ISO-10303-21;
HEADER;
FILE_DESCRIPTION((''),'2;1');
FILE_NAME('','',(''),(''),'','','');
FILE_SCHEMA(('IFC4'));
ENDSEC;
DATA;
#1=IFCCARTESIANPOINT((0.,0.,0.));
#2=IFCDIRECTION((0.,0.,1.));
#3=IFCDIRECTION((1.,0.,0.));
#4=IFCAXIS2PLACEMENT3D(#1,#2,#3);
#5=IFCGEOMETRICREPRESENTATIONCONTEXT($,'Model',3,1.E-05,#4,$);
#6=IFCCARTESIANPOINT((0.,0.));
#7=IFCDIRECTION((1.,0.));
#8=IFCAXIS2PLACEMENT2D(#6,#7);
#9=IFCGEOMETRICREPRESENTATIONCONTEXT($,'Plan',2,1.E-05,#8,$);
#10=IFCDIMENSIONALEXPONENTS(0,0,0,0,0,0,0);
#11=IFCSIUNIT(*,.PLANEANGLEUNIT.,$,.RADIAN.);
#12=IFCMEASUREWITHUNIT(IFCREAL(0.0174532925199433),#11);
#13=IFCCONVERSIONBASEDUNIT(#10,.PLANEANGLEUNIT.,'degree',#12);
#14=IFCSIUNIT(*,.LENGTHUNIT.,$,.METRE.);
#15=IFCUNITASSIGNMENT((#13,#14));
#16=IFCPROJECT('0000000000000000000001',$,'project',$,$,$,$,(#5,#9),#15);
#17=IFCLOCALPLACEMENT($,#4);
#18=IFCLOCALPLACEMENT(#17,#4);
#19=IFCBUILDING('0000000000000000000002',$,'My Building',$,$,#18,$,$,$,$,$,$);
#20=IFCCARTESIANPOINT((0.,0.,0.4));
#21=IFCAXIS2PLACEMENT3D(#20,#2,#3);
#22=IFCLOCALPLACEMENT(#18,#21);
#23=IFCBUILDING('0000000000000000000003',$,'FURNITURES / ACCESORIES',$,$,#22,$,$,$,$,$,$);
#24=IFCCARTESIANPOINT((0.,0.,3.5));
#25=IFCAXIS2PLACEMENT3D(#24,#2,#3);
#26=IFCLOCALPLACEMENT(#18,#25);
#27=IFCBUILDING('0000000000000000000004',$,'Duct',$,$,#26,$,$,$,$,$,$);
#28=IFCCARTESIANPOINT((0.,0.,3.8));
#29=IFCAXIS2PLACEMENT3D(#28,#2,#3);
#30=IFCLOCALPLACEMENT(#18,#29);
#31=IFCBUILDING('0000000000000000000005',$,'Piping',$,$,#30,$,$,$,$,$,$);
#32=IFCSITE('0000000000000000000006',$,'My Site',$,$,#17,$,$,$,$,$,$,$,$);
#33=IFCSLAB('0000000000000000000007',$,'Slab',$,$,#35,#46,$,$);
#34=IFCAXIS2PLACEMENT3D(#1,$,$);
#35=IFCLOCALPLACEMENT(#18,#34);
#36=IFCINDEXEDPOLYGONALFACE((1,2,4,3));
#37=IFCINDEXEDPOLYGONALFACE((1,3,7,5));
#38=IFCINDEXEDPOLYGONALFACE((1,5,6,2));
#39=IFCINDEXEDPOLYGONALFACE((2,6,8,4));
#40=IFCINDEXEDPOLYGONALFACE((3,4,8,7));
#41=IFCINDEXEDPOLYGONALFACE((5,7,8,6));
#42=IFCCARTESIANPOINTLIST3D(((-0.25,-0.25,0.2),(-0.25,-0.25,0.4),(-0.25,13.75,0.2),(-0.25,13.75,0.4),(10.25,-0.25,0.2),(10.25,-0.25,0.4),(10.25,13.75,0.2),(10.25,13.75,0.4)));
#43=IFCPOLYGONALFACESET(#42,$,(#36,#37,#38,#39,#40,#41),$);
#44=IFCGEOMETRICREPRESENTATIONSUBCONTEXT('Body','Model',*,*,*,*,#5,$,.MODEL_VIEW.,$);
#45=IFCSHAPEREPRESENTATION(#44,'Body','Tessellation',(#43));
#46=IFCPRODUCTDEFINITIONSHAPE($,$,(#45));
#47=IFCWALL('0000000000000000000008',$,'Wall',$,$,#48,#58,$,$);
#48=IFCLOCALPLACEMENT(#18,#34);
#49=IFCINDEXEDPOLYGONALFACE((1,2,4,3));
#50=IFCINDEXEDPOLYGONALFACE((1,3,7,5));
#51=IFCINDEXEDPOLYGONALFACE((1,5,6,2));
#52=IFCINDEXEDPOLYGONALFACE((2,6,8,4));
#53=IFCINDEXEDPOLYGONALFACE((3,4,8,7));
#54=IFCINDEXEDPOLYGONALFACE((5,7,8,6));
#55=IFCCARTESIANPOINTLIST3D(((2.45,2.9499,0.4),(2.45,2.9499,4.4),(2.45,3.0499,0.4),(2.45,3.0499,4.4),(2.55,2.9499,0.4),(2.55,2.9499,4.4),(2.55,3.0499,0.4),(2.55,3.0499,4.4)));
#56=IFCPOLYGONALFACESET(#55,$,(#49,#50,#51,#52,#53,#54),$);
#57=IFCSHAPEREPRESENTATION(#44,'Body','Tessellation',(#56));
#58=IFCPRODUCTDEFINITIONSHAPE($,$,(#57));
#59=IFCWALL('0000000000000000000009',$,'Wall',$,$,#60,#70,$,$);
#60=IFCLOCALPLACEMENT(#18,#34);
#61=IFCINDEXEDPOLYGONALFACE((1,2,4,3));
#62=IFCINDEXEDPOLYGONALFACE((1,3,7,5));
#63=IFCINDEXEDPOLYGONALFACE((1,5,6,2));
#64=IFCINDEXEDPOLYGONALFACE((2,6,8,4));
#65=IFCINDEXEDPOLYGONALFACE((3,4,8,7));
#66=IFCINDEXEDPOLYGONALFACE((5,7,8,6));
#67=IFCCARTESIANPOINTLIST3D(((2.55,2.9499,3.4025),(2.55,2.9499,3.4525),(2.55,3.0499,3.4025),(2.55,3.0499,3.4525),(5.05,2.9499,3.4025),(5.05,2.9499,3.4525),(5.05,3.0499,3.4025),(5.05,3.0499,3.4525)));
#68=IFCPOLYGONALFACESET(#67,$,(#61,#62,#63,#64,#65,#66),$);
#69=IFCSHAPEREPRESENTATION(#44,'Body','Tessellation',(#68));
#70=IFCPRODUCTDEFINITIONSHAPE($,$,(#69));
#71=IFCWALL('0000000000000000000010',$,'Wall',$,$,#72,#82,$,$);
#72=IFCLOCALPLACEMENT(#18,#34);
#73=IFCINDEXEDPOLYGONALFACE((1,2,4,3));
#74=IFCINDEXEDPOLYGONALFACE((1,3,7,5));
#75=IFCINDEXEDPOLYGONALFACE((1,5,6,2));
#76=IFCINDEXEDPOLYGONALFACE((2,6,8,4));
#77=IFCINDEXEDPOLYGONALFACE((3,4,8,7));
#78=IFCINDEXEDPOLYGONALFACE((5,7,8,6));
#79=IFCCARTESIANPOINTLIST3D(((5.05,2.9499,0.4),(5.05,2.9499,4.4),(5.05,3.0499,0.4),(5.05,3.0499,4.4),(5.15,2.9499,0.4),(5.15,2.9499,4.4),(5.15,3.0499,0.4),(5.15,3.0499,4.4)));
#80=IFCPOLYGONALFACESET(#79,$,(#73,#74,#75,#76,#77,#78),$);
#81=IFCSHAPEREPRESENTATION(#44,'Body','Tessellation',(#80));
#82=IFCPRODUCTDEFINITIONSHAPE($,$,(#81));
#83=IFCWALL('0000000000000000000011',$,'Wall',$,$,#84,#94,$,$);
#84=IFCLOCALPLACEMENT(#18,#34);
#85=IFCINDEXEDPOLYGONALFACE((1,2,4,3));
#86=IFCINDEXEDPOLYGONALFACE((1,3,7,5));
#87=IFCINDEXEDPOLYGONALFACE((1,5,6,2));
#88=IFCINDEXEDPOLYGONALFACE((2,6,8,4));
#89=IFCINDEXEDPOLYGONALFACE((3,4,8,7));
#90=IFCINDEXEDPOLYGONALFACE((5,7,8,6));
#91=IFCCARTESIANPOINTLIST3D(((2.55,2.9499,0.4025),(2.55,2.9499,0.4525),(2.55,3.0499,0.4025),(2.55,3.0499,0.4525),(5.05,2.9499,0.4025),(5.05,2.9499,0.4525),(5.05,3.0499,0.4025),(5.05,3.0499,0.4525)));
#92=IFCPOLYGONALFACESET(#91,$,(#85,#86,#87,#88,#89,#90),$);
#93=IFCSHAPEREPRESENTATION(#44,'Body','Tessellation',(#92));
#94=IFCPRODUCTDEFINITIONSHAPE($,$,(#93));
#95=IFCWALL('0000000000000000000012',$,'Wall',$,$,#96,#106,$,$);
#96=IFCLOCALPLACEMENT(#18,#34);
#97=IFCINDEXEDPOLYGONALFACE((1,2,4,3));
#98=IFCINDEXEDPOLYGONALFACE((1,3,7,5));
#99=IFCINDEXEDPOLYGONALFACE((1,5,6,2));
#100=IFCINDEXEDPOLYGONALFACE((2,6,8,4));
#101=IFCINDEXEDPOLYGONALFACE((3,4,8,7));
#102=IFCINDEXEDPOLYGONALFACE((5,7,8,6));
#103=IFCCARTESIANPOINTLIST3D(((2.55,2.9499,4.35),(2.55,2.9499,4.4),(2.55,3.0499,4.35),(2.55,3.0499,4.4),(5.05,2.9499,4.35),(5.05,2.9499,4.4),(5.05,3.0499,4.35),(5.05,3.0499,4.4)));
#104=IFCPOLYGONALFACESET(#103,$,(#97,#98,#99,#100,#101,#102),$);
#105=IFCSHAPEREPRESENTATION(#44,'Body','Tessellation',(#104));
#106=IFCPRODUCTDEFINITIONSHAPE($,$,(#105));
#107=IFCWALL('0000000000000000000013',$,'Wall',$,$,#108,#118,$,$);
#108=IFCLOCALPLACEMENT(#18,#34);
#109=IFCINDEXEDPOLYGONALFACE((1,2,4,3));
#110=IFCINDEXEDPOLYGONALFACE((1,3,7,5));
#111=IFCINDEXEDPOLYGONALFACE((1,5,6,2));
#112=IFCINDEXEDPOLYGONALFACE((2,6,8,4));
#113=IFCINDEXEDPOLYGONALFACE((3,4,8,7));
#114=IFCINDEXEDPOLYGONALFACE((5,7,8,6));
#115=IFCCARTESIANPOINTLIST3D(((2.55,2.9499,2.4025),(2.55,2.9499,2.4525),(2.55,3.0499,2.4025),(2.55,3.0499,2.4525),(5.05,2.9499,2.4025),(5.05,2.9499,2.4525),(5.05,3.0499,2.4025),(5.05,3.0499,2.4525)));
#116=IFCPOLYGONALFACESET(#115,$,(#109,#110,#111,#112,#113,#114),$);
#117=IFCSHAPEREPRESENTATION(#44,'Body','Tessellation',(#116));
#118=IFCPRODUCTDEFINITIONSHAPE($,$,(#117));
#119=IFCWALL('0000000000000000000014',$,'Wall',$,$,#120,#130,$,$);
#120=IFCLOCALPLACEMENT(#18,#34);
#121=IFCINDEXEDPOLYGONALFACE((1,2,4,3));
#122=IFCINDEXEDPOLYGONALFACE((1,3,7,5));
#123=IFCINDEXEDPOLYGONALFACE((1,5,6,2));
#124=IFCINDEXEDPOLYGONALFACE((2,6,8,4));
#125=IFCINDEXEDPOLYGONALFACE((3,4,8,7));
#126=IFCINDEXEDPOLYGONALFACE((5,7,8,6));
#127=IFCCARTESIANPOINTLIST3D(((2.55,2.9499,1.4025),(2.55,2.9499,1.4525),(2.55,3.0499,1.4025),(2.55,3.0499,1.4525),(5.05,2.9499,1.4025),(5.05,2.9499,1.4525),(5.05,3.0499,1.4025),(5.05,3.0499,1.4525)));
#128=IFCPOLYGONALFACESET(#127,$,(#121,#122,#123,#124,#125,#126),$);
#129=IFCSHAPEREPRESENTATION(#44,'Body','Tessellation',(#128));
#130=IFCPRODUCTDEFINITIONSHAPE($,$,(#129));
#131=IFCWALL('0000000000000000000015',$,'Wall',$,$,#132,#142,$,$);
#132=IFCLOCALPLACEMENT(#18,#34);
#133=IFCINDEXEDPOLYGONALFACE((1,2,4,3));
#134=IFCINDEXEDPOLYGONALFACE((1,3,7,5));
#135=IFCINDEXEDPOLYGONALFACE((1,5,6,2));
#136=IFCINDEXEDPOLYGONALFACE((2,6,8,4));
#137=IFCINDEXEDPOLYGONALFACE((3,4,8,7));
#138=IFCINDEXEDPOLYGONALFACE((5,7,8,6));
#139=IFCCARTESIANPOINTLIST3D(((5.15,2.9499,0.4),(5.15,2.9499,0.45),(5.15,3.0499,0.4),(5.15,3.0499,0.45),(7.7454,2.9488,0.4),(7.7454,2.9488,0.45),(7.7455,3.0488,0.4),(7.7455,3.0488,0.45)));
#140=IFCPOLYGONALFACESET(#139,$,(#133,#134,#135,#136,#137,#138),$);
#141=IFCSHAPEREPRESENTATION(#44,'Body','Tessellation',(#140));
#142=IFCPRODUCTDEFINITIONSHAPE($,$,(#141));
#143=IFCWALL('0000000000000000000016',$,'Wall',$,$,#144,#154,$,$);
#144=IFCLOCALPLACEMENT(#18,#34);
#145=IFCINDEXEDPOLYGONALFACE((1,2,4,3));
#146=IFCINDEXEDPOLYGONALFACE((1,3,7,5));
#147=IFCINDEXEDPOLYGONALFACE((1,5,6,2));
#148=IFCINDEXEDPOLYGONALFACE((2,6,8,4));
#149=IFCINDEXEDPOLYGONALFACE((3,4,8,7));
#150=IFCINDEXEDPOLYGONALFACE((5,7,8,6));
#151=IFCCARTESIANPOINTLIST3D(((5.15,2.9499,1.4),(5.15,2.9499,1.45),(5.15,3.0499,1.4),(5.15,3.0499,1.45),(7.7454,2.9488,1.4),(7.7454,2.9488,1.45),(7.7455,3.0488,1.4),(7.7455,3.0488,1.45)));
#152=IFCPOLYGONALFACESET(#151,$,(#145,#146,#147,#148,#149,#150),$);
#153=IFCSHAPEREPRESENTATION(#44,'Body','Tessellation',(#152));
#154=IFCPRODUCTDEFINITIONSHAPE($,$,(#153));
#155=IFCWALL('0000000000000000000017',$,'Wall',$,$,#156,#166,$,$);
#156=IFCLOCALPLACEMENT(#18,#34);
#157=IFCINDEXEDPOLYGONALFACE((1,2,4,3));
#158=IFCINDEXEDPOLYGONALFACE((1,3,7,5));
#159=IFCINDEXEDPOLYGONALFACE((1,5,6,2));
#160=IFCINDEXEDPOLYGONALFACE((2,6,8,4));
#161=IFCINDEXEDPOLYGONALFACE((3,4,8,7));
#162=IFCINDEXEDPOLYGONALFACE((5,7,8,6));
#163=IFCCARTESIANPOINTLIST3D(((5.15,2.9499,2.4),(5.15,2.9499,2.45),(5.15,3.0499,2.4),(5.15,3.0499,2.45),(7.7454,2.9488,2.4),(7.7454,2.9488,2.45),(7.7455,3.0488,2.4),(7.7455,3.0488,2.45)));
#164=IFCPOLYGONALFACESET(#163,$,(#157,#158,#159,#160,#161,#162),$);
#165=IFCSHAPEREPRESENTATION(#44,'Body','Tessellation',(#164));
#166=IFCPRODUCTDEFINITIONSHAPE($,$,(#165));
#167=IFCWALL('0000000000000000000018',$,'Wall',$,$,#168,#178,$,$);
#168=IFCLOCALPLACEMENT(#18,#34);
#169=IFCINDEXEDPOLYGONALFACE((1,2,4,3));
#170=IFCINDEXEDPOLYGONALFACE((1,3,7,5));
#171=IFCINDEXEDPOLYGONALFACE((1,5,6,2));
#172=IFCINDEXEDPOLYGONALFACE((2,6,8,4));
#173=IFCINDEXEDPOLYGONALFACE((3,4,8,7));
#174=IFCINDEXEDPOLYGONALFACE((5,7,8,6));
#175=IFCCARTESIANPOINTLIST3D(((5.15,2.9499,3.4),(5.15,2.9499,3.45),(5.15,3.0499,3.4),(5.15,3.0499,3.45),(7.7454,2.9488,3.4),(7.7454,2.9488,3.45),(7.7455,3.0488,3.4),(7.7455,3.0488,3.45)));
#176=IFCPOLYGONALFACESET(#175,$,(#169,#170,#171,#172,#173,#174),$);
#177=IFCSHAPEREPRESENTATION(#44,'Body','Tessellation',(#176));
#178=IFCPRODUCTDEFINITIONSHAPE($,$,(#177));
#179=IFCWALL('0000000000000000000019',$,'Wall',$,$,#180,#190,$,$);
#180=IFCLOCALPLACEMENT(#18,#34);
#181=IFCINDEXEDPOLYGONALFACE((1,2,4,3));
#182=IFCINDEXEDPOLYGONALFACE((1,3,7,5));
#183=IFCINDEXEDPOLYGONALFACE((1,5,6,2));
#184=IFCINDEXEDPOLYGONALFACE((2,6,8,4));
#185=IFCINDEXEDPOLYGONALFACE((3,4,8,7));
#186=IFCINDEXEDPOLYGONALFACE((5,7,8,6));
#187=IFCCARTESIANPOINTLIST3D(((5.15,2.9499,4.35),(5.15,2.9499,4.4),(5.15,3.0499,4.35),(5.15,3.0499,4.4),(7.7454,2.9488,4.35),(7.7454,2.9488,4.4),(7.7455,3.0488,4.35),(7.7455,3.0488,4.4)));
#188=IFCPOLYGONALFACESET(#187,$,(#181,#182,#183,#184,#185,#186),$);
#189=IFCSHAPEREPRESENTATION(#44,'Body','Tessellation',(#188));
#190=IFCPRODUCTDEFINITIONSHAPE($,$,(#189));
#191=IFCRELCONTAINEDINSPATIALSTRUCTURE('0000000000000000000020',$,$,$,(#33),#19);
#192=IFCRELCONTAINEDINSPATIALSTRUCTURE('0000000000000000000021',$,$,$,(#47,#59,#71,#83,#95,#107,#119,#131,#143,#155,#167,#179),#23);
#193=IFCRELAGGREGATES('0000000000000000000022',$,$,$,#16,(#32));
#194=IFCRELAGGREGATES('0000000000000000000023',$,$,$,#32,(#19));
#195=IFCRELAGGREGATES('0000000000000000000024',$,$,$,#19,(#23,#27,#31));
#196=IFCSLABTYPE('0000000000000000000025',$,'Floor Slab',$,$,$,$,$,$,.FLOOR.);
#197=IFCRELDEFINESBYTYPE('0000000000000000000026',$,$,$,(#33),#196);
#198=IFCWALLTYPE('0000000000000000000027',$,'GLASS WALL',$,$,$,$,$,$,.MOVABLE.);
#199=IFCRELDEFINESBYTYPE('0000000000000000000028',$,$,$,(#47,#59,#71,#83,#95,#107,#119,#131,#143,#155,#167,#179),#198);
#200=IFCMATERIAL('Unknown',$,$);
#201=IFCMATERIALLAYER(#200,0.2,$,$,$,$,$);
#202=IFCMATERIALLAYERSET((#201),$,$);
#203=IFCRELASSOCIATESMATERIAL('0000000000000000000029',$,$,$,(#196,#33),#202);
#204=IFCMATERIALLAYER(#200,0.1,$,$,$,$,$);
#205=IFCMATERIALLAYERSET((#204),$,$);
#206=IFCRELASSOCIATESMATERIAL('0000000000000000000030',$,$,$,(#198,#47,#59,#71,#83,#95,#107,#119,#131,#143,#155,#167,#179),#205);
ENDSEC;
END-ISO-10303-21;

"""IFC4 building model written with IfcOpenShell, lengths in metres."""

from ifc_helpers import new_model, entity, si_unit, converted_unit, frame, origin_with_axes, origin_2d_with_axis, place, context, subcontext, project, spatial, line, indexed_curve, outline, extrude, material, layer, layer_set, layer_usage, type_object, element, save


model = new_model("IFC4")

# Units and contexts
model_context = context("Model", 3, precision=1e-05, world=origin_with_axes())
plan_context = context("Plan", 2, precision=1e-05, world=origin_2d_with_axis())
body_context = subcontext(model_context, "Body", "Model", "MODEL_VIEW")
ifc_project = project(units=[converted_unit("PLANEANGLEUNIT", "degree", entity("IfcReal", 0.0174532925199433), si_unit("PLANEANGLEUNIT", "RADIAN"), dimensions=[0, 0, 0, 0, 0, 0, 0]), si_unit("LENGTHUNIT", "METRE")], contexts=[model_context, plan_context])

# Site, building
site_placement = place(None, origin_with_axes())
site = spatial("IfcSite", under=ifc_project, at=site_placement, Name="My Site")
building_1_placement = place(site_placement, origin_with_axes())
building_1 = spatial("IfcBuilding", under=site, at=building_1_placement, Name="My Building")

# Slab
ifc_material = material(Name="Unknown")
ifc_layer_1 = layer(ifc_material, 0.2)
ifc_layer_set_1 = layer_set([ifc_layer_1])
ifc_layer_usage_1 = layer_usage(ifc_layer_set_1, "AXIS3", "POSITIVE", 0.0)
slab_type = type_object("IfcSlabType", Name="Floor Slab", PredefinedType="FLOOR", material=ifc_layer_set_1)
slab_placement = place(building_1_placement, frame((-0.25, -0.25, 0.2), z_axis=(0.0, 0.0, 1.0), x_axis=(1.0, 0.0, 0.0)))
element("IfcSlab", 1, at=slab_placement, inside=building_1, type_object=slab_type, material=ifc_layer_usage_1, Name="Slab", context=body_context, shape_type="SweptSolid", body=[
    extrude(outline(indexed_curve([(0.0, 0.0), (10.5, 0.0), (10.5, 14.0), (0.0, 14.0), (0.0, 0.0)])), None, (0.0, 0.0, 1.0), 0.2),
])

# Shared definitions
building_2_placement = place(building_1_placement, frame((0.0, 0.0, 0.4), z_axis=(0.0, 0.0, 1.0), x_axis=(1.0, 0.0, 0.0)))
building_2 = spatial("IfcBuilding", under=building_1, at=building_2_placement, Name="FURNITURES / ACCESORIES")

# Walls
ifc_layer_2 = layer(ifc_material, 0.1)
ifc_layer_set_2 = layer_set([ifc_layer_2])
ifc_layer_usage_2 = layer_usage(ifc_layer_set_2, "AXIS2", "POSITIVE", 0.0)
wall_type = type_object("IfcWallType", Name="GLASS WALL", PredefinedType="MOVABLE", material=ifc_layer_set_2)
wall_1_placement = place(building_2_placement, frame((2.45, 2.9499, 0.0), z_axis=(0.0, 0.0, 1.0), x_axis=(1.0, 0.0, 0.0)))
element("IfcWall", 2, at=wall_1_placement, inside=building_2, type_object=wall_type, material=ifc_layer_usage_2, Name="Wall", context=body_context, shape_type="SweptSolid", body=[
    extrude(outline(indexed_curve([(0.0, 0.0), (0.0, 0.1), (0.1, 0.1), (0.1, 0.0)], segments=[line(1, 2, 3, 4, 1)])), origin_with_axes(), (0.0, 0.0, 1.0), 4.0),
])
ifc_layer_usage_3 = layer_usage(ifc_layer_set_2, "AXIS2", "POSITIVE", 0.0)
wall_2_placement = place(building_2_placement, frame((2.55, 2.9499, 3.0025), z_axis=(0.0, 0.0, 1.0), x_axis=(1.0, 0.0, 0.0)))
element("IfcWall", 3, at=wall_2_placement, inside=building_2, type_object=wall_type, material=ifc_layer_usage_3, Name="Wall", context=body_context, shape_type="SweptSolid", body=[
    extrude(outline(indexed_curve([(0.0, 0.0), (0.0, 0.1), (2.5, 0.1), (2.5, 0.0)], segments=[line(1, 2, 3, 4, 1)])), origin_with_axes(), (0.0, 0.0, 1.0), 0.05),
])
ifc_layer_usage_4 = layer_usage(ifc_layer_set_2, "AXIS2", "POSITIVE", 0.0)
wall_3_placement = place(building_2_placement, frame((5.05, 2.9499, 0.0), z_axis=(0.0, 0.0, 1.0), x_axis=(1.0, 0.0, 0.0)))
element("IfcWall", 4, at=wall_3_placement, inside=building_2, type_object=wall_type, material=ifc_layer_usage_4, Name="Wall", context=body_context, shape_type="SweptSolid", body=[
    extrude(outline(indexed_curve([(0.0, 0.0), (0.0, 0.1), (0.1, 0.1), (0.1, 0.0)], segments=[line(1, 2, 3, 4, 1)])), origin_with_axes(), (0.0, 0.0, 1.0), 4.0),
])
ifc_layer_usage_5 = layer_usage(ifc_layer_set_2, "AXIS2", "POSITIVE", 0.0)
wall_4_placement = place(building_2_placement, frame((2.55, 2.9499, 0.0025), z_axis=(0.0, 0.0, 1.0), x_axis=(1.0, 0.0, 0.0)))
element("IfcWall", 5, at=wall_4_placement, inside=building_2, type_object=wall_type, material=ifc_layer_usage_5, Name="Wall", context=body_context, shape_type="SweptSolid", body=[
    extrude(outline(indexed_curve([(0.0, 0.0), (0.0, 0.1), (2.5, 0.1), (2.5, 0.0)], segments=[line(1, 2, 3, 4, 1)])), origin_with_axes(), (0.0, 0.0, 1.0), 0.05),
])
ifc_layer_usage_6 = layer_usage(ifc_layer_set_2, "AXIS2", "POSITIVE", 0.0)
wall_5_placement = place(building_2_placement, frame((2.55, 2.9499, 3.95), z_axis=(0.0, 0.0, 1.0), x_axis=(1.0, 0.0, 0.0)))
element("IfcWall", 6, at=wall_5_placement, inside=building_2, type_object=wall_type, material=ifc_layer_usage_6, Name="Wall", context=body_context, shape_type="SweptSolid", body=[
    extrude(outline(indexed_curve([(0.0, 0.0), (0.0, 0.1), (2.5, 0.1), (2.5, 0.0)], segments=[line(1, 2, 3, 4, 1)])), origin_with_axes(), (0.0, 0.0, 1.0), 0.05),
])
ifc_layer_usage_7 = layer_usage(ifc_layer_set_2, "AXIS2", "POSITIVE", 0.0)
wall_6_placement = place(building_2_placement, frame((2.55, 2.9499, 2.0025), z_axis=(0.0, 0.0, 1.0), x_axis=(1.0, 0.0, 0.0)))
element("IfcWall", 7, at=wall_6_placement, inside=building_2, type_object=wall_type, material=ifc_layer_usage_7, Name="Wall", context=body_context, shape_type="SweptSolid", body=[
    extrude(outline(indexed_curve([(0.0, 0.0), (0.0, 0.1), (2.5, 0.1), (2.5, 0.0)], segments=[line(1, 2, 3, 4, 1)])), origin_with_axes(), (0.0, 0.0, 1.0), 0.05),
])
ifc_layer_usage_8 = layer_usage(ifc_layer_set_2, "AXIS2", "POSITIVE", 0.0)
wall_7_placement = place(building_2_placement, frame((2.55, 2.9499, 1.0025), z_axis=(0.0, 0.0, 1.0), x_axis=(1.0, 0.0, 0.0)))
element("IfcWall", 8, at=wall_7_placement, inside=building_2, type_object=wall_type, material=ifc_layer_usage_8, Name="Wall", context=body_context, shape_type="SweptSolid", body=[
    extrude(outline(indexed_curve([(0.0, 0.0), (0.0, 0.1), (2.5, 0.1), (2.5, 0.0)], segments=[line(1, 2, 3, 4, 1)])), origin_with_axes(), (0.0, 0.0, 1.0), 0.05),
])
ifc_layer_usage_9 = layer_usage(ifc_layer_set_2, "AXIS2", "POSITIVE", 0.0)
wall_8_placement = place(building_2_placement, frame((5.15, 2.9499, 0.0), z_axis=(0.0, 0.0, 1.0), x_axis=(1.0, -0.000449, 0.0)))
element("IfcWall", 9, at=wall_8_placement, inside=building_2, type_object=wall_type, material=ifc_layer_usage_9, Name="Wall", context=body_context, shape_type="SweptSolid", body=[
    extrude(outline(indexed_curve([(0.0, 0.0), (0.0, 0.1), (2.5954, 0.1), (2.5954, 0.0)], segments=[line(1, 2, 3, 4, 1)])), origin_with_axes(), (0.0, 0.0, 1.0), 0.05),
])
ifc_layer_usage_10 = layer_usage(ifc_layer_set_2, "AXIS2", "POSITIVE", 0.0)
wall_9_placement = place(building_2_placement, frame((5.15, 2.9499, 1.0), z_axis=(0.0, 0.0, 1.0), x_axis=(1.0, -0.000449, 0.0)))
element("IfcWall", 10, at=wall_9_placement, inside=building_2, type_object=wall_type, material=ifc_layer_usage_10, Name="Wall", context=body_context, shape_type="SweptSolid", body=[
    extrude(outline(indexed_curve([(0.0, 0.0), (0.0, 0.1), (2.5954, 0.1), (2.5954, 0.0)], segments=[line(1, 2, 3, 4, 1)])), origin_with_axes(), (0.0, 0.0, 1.0), 0.05),
])
ifc_layer_usage_11 = layer_usage(ifc_layer_set_2, "AXIS2", "POSITIVE", 0.0)
wall_10_placement = place(building_2_placement, frame((5.15, 2.9499, 2.0), z_axis=(0.0, 0.0, 1.0), x_axis=(1.0, -0.000449, 0.0)))
element("IfcWall", 11, at=wall_10_placement, inside=building_2, type_object=wall_type, material=ifc_layer_usage_11, Name="Wall", context=body_context, shape_type="SweptSolid", body=[
    extrude(outline(indexed_curve([(0.0, 0.0), (0.0, 0.1), (2.5954, 0.1), (2.5954, 0.0)], segments=[line(1, 2, 3, 4, 1)])), origin_with_axes(), (0.0, 0.0, 1.0), 0.05),
])
ifc_layer_usage_12 = layer_usage(ifc_layer_set_2, "AXIS2", "POSITIVE", 0.0)
wall_11_placement = place(building_2_placement, frame((5.15, 2.9499, 3.0), z_axis=(0.0, 0.0, 1.0), x_axis=(1.0, -0.000449, 0.0)))
element("IfcWall", 12, at=wall_11_placement, inside=building_2, type_object=wall_type, material=ifc_layer_usage_12, Name="Wall", context=body_context, shape_type="SweptSolid", body=[
    extrude(outline(indexed_curve([(0.0, 0.0), (0.0, 0.1), (2.5954, 0.1), (2.5954, 0.0)], segments=[line(1, 2, 3, 4, 1)])), origin_with_axes(), (0.0, 0.0, 1.0), 0.05),
])
ifc_layer_usage_13 = layer_usage(ifc_layer_set_2, "AXIS2", "POSITIVE", 0.0)
wall_12_placement = place(building_2_placement, frame((5.15, 2.9499, 3.95), z_axis=(0.0, 0.0, 1.0), x_axis=(1.0, -0.000449, 0.0)))
element("IfcWall", 13, at=wall_12_placement, inside=building_2, type_object=wall_type, material=ifc_layer_usage_13, Name="Wall", context=body_context, shape_type="SweptSolid", body=[
    extrude(outline(indexed_curve([(0.0, 0.0), (0.0, 0.1), (2.5954, 0.1), (2.5954, 0.0)], segments=[line(1, 2, 3, 4, 1)])), origin_with_axes(), (0.0, 0.0, 1.0), 0.05),
])

# Shared definitions
building_3_placement = place(building_1_placement, frame((0.0, 0.0, 3.5), z_axis=(0.0, 0.0, 1.0), x_axis=(1.0, 0.0, 0.0)))
building_3 = spatial("IfcBuilding", under=building_1, at=building_3_placement, Name="Duct")

# Shared definitions
building_4_placement = place(building_1_placement, frame((0.0, 0.0, 3.8), z_axis=(0.0, 0.0, 1.0), x_axis=(1.0, 0.0, 0.0)))
building_4 = spatial("IfcBuilding", under=building_1, at=building_4_placement, Name="Piping")

save(model, "model.ifc")
